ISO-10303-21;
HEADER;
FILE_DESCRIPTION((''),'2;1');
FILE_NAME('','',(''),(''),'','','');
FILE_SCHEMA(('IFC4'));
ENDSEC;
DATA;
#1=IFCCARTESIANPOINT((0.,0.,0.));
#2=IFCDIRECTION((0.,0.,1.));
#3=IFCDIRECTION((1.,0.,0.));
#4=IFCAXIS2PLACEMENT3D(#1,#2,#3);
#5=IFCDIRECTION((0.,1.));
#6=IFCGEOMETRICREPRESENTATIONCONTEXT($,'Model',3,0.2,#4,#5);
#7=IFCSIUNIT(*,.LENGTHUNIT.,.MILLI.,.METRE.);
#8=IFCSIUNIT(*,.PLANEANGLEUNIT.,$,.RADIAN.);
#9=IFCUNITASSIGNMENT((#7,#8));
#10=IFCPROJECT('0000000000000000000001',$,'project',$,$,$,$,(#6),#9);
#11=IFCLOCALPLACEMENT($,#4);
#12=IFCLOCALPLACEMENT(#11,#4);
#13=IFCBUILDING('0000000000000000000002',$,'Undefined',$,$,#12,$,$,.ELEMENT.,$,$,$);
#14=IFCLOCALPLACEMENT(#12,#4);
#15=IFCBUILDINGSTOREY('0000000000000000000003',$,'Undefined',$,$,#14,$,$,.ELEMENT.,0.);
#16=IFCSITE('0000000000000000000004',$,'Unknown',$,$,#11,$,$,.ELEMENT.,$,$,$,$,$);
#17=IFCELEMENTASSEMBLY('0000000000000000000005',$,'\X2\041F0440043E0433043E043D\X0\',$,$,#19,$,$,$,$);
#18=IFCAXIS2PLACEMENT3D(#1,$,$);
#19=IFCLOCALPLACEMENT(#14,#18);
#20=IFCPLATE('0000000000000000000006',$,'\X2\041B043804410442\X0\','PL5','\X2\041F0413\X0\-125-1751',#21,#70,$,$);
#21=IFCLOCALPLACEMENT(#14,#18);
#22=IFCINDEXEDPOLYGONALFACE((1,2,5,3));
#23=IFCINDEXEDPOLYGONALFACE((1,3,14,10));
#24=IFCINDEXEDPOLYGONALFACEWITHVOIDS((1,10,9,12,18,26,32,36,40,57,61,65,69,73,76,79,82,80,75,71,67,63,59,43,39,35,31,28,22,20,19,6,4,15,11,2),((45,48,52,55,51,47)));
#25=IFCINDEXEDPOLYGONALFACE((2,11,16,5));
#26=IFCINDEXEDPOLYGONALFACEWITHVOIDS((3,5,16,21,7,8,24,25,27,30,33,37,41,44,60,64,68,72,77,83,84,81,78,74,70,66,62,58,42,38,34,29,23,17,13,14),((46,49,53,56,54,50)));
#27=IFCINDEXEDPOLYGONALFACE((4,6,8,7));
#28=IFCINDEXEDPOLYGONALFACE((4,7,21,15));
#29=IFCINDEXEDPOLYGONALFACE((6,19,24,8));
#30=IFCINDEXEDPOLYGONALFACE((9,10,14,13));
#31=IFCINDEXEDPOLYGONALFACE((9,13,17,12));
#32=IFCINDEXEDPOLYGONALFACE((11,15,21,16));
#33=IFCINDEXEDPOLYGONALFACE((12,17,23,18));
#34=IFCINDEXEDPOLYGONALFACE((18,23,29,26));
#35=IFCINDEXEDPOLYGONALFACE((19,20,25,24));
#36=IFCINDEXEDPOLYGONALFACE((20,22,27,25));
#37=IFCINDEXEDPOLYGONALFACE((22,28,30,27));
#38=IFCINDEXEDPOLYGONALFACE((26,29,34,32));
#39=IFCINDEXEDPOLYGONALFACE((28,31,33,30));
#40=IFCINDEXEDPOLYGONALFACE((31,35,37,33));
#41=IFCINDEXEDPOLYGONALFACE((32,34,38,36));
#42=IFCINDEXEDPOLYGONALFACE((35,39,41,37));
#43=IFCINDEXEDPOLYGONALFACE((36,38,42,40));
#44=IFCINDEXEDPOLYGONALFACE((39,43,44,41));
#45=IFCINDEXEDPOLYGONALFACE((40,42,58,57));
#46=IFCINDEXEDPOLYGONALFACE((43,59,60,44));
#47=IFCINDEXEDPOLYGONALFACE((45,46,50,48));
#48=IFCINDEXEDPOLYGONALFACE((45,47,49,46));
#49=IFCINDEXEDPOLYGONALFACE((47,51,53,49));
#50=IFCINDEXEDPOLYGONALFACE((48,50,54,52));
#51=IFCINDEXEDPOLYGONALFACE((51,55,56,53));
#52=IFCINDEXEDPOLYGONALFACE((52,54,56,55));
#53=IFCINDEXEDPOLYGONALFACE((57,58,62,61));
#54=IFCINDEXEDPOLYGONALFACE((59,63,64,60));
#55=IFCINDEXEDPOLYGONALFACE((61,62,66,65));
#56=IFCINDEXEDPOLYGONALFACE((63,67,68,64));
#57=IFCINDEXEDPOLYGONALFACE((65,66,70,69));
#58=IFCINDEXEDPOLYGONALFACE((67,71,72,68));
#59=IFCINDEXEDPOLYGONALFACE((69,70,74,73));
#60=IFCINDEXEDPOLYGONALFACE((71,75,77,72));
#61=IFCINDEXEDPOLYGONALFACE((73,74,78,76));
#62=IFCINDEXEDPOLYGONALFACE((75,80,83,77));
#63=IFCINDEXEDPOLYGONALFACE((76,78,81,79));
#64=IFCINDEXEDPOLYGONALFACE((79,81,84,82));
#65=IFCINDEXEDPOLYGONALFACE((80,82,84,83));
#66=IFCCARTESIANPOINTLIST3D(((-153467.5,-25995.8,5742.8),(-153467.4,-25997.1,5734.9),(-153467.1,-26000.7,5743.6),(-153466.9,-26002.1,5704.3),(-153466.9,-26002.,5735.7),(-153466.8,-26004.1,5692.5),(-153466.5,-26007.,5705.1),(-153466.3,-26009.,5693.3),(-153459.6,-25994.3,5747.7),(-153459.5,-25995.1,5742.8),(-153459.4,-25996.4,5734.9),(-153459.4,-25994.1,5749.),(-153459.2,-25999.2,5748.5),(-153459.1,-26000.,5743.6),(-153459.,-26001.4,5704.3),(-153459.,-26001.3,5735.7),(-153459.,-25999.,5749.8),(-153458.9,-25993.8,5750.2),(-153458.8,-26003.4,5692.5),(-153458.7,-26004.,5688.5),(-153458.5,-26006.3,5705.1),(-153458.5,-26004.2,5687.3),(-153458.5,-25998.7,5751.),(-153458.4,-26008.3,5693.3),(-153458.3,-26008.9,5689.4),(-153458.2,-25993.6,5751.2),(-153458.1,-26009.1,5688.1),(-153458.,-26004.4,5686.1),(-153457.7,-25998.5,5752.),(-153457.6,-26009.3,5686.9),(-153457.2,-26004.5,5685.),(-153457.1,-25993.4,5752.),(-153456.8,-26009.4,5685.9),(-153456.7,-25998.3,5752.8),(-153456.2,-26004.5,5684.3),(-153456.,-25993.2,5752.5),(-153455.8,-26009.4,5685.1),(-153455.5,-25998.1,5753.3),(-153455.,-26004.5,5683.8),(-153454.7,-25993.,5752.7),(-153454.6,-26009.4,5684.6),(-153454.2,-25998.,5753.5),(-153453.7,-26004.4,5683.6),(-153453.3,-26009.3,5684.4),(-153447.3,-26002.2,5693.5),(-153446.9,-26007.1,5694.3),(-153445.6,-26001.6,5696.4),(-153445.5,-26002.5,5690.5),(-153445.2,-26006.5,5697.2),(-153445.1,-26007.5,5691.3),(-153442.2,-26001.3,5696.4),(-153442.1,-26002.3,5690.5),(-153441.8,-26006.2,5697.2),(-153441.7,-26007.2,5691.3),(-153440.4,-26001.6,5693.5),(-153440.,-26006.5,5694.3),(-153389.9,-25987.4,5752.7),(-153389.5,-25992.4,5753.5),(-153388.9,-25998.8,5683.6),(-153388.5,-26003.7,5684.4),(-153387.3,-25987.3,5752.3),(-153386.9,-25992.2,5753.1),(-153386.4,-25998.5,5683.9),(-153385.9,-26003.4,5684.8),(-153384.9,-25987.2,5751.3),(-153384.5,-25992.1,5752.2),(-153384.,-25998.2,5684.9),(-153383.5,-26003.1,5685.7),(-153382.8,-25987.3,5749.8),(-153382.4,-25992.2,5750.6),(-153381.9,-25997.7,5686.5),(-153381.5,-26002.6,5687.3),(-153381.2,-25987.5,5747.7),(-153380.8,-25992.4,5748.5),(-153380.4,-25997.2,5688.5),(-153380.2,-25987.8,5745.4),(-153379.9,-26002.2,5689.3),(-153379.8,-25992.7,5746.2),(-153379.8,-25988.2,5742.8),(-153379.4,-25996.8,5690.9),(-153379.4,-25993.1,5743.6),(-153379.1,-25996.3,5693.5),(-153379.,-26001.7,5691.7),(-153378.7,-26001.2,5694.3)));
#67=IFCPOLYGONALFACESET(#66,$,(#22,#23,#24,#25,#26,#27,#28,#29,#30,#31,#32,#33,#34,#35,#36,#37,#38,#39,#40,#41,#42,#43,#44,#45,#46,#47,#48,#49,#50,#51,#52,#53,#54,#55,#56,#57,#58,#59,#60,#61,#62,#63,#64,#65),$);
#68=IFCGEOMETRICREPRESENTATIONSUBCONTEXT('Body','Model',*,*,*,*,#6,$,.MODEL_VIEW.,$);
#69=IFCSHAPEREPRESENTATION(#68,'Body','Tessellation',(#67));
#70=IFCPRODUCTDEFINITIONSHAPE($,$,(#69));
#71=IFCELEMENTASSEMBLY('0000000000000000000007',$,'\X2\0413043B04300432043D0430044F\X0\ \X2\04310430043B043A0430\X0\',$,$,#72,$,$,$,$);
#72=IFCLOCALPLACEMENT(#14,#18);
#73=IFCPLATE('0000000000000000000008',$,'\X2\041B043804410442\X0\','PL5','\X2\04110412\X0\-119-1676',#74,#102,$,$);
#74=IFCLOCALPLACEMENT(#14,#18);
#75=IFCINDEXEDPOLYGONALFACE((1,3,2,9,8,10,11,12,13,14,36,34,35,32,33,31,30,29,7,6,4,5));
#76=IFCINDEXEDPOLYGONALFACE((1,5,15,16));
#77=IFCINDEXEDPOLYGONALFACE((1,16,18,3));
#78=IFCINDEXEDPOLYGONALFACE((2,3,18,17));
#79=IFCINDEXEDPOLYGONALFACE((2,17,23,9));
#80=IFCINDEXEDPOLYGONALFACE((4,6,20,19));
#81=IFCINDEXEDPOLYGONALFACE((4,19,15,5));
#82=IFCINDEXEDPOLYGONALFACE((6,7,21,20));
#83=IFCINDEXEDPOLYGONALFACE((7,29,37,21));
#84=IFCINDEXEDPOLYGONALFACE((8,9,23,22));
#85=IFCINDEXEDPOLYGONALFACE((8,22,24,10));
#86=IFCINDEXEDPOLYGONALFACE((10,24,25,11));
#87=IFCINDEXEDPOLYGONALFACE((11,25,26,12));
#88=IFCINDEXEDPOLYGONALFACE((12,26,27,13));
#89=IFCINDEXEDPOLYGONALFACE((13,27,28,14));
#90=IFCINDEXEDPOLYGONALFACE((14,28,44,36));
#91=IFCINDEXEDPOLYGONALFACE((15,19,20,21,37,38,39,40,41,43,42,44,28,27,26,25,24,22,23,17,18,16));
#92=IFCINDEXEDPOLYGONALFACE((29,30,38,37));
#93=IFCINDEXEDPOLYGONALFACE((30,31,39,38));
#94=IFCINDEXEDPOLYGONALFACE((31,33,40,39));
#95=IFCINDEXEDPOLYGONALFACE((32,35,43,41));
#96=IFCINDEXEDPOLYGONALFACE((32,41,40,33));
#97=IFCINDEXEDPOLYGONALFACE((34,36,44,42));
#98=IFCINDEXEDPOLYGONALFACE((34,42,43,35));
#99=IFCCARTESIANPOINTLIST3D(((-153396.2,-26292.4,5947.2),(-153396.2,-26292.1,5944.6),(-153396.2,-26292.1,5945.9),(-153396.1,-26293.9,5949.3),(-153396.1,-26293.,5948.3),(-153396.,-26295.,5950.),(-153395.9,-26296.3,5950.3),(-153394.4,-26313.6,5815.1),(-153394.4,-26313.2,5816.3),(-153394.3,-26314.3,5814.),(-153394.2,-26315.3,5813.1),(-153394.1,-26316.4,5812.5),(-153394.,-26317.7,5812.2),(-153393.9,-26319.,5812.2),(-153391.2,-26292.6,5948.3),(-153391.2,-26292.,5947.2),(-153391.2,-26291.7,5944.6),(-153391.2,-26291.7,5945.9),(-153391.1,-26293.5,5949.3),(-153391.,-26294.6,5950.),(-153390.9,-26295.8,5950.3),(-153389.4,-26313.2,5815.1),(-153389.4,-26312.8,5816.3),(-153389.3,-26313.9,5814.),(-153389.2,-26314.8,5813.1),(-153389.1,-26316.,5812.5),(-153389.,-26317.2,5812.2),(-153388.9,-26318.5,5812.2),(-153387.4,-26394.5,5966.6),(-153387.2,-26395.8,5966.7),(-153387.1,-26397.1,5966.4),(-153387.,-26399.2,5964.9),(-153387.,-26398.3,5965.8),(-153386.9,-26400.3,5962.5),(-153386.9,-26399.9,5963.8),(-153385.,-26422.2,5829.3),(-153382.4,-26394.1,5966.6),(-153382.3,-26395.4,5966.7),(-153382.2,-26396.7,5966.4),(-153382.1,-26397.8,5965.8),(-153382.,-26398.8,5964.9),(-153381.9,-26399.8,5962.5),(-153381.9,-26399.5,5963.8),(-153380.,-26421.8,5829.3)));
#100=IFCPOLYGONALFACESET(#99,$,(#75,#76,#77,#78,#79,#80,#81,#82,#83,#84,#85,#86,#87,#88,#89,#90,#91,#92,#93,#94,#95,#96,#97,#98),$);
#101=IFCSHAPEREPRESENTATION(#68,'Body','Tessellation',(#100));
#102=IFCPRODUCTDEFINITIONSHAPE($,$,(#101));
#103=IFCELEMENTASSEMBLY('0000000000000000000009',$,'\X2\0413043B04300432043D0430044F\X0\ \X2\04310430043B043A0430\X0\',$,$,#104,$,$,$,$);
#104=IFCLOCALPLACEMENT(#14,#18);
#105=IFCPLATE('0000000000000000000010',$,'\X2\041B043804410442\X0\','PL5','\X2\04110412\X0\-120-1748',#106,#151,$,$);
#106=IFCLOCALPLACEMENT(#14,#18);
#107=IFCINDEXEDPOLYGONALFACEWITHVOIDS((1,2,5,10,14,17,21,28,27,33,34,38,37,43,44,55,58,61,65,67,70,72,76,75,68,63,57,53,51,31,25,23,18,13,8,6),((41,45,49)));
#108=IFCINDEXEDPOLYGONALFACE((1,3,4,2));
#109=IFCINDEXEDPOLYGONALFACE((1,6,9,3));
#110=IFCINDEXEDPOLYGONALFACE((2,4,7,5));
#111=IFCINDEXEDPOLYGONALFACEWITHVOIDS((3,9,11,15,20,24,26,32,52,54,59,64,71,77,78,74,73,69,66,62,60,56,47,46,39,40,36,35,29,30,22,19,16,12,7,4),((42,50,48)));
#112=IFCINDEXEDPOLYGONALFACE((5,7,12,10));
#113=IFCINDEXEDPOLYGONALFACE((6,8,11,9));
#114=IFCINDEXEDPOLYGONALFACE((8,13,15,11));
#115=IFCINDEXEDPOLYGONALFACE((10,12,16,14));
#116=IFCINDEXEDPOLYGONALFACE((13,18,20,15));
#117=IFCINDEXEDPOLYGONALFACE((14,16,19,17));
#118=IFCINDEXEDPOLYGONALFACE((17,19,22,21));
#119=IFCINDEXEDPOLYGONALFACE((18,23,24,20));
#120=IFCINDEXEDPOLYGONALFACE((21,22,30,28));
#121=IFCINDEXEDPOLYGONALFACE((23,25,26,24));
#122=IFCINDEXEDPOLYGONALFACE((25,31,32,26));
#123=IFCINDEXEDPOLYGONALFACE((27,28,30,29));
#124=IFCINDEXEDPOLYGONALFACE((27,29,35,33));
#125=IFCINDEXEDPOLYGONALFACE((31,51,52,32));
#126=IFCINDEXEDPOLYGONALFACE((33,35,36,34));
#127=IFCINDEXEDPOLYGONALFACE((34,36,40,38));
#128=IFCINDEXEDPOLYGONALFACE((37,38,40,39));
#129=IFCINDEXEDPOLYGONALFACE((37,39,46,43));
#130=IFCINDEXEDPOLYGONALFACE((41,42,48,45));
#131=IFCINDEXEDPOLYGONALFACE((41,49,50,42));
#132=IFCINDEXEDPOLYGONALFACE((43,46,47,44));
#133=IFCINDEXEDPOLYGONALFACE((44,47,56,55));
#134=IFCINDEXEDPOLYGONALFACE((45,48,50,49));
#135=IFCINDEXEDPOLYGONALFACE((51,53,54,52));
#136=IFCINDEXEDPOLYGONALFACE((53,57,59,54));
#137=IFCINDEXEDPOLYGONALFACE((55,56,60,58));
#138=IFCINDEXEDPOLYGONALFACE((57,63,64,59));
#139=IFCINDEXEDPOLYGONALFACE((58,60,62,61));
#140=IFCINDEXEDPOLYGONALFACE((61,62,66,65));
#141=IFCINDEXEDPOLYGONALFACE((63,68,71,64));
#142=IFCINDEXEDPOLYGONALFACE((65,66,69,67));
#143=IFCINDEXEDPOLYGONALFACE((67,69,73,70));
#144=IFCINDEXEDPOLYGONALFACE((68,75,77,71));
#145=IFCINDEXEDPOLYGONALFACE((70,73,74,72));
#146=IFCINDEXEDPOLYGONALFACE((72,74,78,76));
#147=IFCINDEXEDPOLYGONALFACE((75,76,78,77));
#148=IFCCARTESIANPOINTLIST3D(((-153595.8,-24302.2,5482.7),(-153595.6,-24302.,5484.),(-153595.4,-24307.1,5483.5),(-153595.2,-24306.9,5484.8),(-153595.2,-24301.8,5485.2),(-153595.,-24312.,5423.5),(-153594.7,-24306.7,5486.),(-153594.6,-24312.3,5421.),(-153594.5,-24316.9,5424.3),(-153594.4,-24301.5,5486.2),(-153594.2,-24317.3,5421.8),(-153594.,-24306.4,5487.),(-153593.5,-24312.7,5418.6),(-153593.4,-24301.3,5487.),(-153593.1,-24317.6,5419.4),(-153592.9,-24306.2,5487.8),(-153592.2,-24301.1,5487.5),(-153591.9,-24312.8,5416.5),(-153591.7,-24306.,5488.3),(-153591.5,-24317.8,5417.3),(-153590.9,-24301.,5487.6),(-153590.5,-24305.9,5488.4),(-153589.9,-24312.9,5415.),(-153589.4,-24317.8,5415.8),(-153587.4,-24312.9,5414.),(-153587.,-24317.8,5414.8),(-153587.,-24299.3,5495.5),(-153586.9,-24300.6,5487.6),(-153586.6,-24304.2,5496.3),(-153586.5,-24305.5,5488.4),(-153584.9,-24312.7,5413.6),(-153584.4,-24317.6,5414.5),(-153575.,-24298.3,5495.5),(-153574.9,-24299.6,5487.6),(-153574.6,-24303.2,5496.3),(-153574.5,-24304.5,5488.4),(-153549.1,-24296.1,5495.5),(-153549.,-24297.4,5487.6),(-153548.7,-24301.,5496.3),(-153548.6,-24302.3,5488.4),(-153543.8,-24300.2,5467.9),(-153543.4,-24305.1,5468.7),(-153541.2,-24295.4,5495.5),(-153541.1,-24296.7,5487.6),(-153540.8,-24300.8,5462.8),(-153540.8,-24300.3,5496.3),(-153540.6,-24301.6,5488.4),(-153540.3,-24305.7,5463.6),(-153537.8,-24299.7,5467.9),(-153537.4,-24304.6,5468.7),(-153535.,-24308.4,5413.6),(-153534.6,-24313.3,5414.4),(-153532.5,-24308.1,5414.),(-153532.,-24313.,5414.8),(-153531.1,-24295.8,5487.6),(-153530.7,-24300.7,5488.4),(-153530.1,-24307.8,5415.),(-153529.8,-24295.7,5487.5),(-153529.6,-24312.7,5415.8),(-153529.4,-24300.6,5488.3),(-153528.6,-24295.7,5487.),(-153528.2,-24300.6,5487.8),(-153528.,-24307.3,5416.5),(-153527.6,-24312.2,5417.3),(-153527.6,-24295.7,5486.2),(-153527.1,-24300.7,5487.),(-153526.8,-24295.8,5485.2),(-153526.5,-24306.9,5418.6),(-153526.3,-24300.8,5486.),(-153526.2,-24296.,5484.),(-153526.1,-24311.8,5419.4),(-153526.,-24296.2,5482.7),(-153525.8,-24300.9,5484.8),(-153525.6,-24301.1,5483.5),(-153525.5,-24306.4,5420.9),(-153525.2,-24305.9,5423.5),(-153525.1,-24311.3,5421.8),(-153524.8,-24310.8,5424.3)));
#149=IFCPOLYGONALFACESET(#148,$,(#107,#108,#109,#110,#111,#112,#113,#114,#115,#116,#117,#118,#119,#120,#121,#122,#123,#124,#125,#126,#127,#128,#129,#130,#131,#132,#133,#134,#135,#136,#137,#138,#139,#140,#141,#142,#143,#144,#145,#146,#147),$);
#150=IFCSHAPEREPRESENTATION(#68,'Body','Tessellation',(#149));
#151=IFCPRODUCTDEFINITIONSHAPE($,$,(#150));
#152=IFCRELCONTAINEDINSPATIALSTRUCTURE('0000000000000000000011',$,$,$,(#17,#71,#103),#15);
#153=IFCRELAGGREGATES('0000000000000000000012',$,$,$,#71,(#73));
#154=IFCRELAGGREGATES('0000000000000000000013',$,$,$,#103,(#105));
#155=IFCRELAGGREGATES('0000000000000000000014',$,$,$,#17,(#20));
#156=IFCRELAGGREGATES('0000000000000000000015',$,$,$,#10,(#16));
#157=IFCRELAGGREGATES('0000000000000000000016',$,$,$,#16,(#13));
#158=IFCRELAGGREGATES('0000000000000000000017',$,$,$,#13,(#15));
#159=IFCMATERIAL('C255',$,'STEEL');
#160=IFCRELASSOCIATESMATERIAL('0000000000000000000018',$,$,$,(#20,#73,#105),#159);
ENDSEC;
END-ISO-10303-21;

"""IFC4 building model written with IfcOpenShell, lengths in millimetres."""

from ifc_helpers import new_model, si_unit, direction, frame, origin_with_axes, place, context, subcontext, project, spatial, line, arc, indexed_curve, outline, extrude, material, element, aggregate, save


model = new_model("IFC4")

# Units and contexts
model_context = context("Model", 3, precision=0.2, world=origin_with_axes(), true_north=direction((0.0, 1.0)))
body_context = subcontext(model_context, "Body", "Model", "MODEL_VIEW")
ifc_project = project(units=[si_unit("LENGTHUNIT", "METRE", prefix="MILLI"), si_unit("PLANEANGLEUNIT", "RADIAN")], contexts=[model_context])

# Site, building, storey
site_placement = place(None, origin_with_axes())
site = spatial("IfcSite", under=ifc_project, at=site_placement, Name="Unknown", CompositionType="ELEMENT")
building_placement = place(site_placement, origin_with_axes())
building = spatial("IfcBuilding", under=site, at=building_placement, Name="Undefined", CompositionType="ELEMENT")
storey_placement = place(building_placement, origin_with_axes())
storey = spatial("IfcBuildingStorey", under=building, at=storey_placement, Name="Undefined", CompositionType="ELEMENT", Elevation=0.0)

# Shared definitions
ifc_material_1 = material(Name="C255", Category="STEEL")

# Element assembly, plate, voiding feature
assembly_1_placement = place(storey_placement, frame((-153498.6, -26006.9, 3248.5), z_axis=(0.086114, -0.996285, 0.0), x_axis=(0.0, 0.0, 1.0)))
assembly_1 = element("IfcElementAssembly", 1, at=assembly_1_placement, inside=storey, Name="Прогон")
plate_1_placement = place(assembly_1_placement, frame((2504.5, -120.0, -7.5), z_axis=(-0.162881, -0.000054, -0.986646), x_axis=(-0.986646, 0.000078, 0.162881)))
plate_1 = element("IfcPlate", 2, at=plate_1_placement, material=ifc_material_1, Name="Лист", Description="PL5", ObjectType="ПГ-125-1751", context=body_context, shape_type="SolidModel", body=[
    extrude(outline(indexed_curve([(0.0, 10.0), (2.9, 2.9), (10.0, 0.0), (60.0, 0.0), (67.1, 2.9), (70.0, 10.0), (70.0, 75.0), (68.5, 78.5), (65.0, 80.0), (61.0, 80.0), (61.0, 88.0), (49.0, 88.0), (49.0, 80.0), (18.0, 80.0), (18.0, 88.0), (10.0, 88.0), (10.0, 80.0), (5.0, 80.0), (1.5, 78.5), (0.0, 75.0)], segments=[arc(1, 2, 3), line(3, 4), arc(4, 5, 6), line(6, 7), arc(7, 8, 9), line(9, 10, 11, 12, 13, 14, 15, 16, 17, 18), arc(18, 19, 20), line(20, 1)])), frame((0.0, 0.0, 2.5), z_axis=(0.0, 0.0, 1.0), x_axis=(1.0, 0.0, 0.0)), (0.0, 0.0, -1.0), 5.0),
])
voiding_feature_1_placement = place(plate_1_placement, frame((60.0, 65.0, 6.0), z_axis=(-0.000054, -1.0, 0.000034), x_axis=(0.0, -0.000034, -1.0)))
element("IfcVoidingFeature", 3, at=voiding_feature_1_placement, cuts=plate_1, Name="Балка", ObjectType="(?)", PredefinedType="HOLE", context=body_context, shape_type="SolidModel", body=[
    extrude(outline(indexed_curve([(1.7, -3.0), (3.5, 0.0), (1.7, 3.0), (-1.7, 3.0), (-3.5, 0.0), (-1.7, -3.0)], segments=[line(1, 2, 3, 4, 5, 6, 1)])), frame((0.0, 0.0, 0.0), z_axis=(-1.0, 0.0, 0.0), x_axis=(0.0, 0.0, 1.0)), (0.0, 0.0, -1.0), 12.0),
])

# Element assembly, plate
assembly_2_placement = place(storey_placement, frame((-153404.6, -26166.6, 5857.9), z_axis=(-0.996285, -0.086114, 0.000024), x_axis=(0.084961, -0.982981, 0.162881)))
assembly_2 = element("IfcElementAssembly", 4, at=assembly_2_placement, inside=storey, Name="Главная балка")
plate_2_placement = place(assembly_2_placement, frame((138.2, 70.0, 0.0), z_axis=(0.0, 0.0, 1.0), x_axis=(0.0, -1.0, 0.0)))
plate_2 = element("IfcPlate", 5, at=plate_2_placement, material=ifc_material_1, Name="Лист", Description="PL5", ObjectType="БВ-119-1676", context=body_context, shape_type="SolidModel", body=[
    extrude(outline(indexed_curve([(0.0, 5.0), (1.5, 1.5), (5.0, 0.0), (135.0, 0.0), (138.5, 1.5), (140.0, 5.0), (140.0, 110.0), (5.0, 110.0), (1.5, 108.5), (0.0, 105.0)], segments=[arc(1, 2, 3), line(3, 4), arc(4, 5, 6), line(6, 7, 8), arc(8, 9, 10), line(10, 1)])), frame((0.0, 0.0, 2.5), z_axis=(0.0, 0.0, 1.0), x_axis=(1.0, 0.0, 0.0)), (0.0, 0.0, -1.0), 5.0),
])
aggregate(assembly_2, [plate_2])

# Element assembly, plate, voiding feature
assembly_3_placement = place(storey_placement, frame((-153597.6, -23933.2, 5487.9), z_axis=(-0.996285, -0.086114, 0.000024), x_axis=(0.084961, -0.982981, 0.162881)))
assembly_3 = element("IfcElementAssembly", 6, at=assembly_3_placement, inside=storey, Name="Главная балка")
plate_3_placement = place(assembly_3_placement, frame((364.5, -135.0, -40.0), z_axis=(-1.0, -0.000054, 0.0), x_axis=(0.0, 0.000054, 1.0)))
plate_3 = element("IfcPlate", 7, at=plate_3_placement, material=ifc_material_1, Name="Лист", Description="PL5", ObjectType="БВ-120-1748", context=body_context, shape_type="SolidModel", body=[
    extrude(outline(indexed_curve([(0.0, 10.0), (2.9, 2.9), (10.0, 0.0), (60.0, 0.0), (67.1, 2.9), (70.0, 10.0), (70.0, 70.0), (68.5, 73.5), (65.0, 75.0), (61.0, 75.0), (61.0, 83.0), (49.0, 83.0), (49.0, 75.0), (23.0, 75.0), (23.0, 83.0), (15.0, 83.0), (15.0, 75.0), (5.0, 75.0), (1.5, 73.5), (0.0, 70.0)], segments=[arc(1, 2, 3), line(3, 4), arc(4, 5, 6), line(6, 7), arc(7, 8, 9), line(9, 10, 11, 12, 13, 14, 15, 16, 17, 18), arc(18, 19, 20), line(20, 1)])), frame((0.0, 0.0, 2.5), z_axis=(0.0, 0.0, 1.0), x_axis=(1.0, 0.0, 0.0)), (0.0, 0.0, -1.0), 5.0),
])
voiding_feature_2_placement = place(plate_3_placement, frame((15.0, 55.0, 10.0), z_axis=(0.007997, -0.999968, -0.000026), x_axis=(0.0, 0.000026, -1.0)))
element("IfcVoidingFeature", 8, at=voiding_feature_2_placement, cuts=plate_3, Name="Балка", ObjectType="(?)", PredefinedType="HOLE", context=body_context, shape_type="SolidModel", body=[
    extrude(outline(indexed_curve([(0.0, -3.0), (5.2, 0.0), (0.0, 3.0)], segments=[line(1, 2, 3, 1)])), frame((0.0, 0.0, 0.0), z_axis=(-1.0, 0.0, 0.0), x_axis=(0.0, 0.0, 1.0)), (0.0, 0.0, -1.0), 20.0),
])
aggregate(assembly_3, [plate_3])

aggregate(assembly_1, [plate_1])

save(model, "model.ifc")
